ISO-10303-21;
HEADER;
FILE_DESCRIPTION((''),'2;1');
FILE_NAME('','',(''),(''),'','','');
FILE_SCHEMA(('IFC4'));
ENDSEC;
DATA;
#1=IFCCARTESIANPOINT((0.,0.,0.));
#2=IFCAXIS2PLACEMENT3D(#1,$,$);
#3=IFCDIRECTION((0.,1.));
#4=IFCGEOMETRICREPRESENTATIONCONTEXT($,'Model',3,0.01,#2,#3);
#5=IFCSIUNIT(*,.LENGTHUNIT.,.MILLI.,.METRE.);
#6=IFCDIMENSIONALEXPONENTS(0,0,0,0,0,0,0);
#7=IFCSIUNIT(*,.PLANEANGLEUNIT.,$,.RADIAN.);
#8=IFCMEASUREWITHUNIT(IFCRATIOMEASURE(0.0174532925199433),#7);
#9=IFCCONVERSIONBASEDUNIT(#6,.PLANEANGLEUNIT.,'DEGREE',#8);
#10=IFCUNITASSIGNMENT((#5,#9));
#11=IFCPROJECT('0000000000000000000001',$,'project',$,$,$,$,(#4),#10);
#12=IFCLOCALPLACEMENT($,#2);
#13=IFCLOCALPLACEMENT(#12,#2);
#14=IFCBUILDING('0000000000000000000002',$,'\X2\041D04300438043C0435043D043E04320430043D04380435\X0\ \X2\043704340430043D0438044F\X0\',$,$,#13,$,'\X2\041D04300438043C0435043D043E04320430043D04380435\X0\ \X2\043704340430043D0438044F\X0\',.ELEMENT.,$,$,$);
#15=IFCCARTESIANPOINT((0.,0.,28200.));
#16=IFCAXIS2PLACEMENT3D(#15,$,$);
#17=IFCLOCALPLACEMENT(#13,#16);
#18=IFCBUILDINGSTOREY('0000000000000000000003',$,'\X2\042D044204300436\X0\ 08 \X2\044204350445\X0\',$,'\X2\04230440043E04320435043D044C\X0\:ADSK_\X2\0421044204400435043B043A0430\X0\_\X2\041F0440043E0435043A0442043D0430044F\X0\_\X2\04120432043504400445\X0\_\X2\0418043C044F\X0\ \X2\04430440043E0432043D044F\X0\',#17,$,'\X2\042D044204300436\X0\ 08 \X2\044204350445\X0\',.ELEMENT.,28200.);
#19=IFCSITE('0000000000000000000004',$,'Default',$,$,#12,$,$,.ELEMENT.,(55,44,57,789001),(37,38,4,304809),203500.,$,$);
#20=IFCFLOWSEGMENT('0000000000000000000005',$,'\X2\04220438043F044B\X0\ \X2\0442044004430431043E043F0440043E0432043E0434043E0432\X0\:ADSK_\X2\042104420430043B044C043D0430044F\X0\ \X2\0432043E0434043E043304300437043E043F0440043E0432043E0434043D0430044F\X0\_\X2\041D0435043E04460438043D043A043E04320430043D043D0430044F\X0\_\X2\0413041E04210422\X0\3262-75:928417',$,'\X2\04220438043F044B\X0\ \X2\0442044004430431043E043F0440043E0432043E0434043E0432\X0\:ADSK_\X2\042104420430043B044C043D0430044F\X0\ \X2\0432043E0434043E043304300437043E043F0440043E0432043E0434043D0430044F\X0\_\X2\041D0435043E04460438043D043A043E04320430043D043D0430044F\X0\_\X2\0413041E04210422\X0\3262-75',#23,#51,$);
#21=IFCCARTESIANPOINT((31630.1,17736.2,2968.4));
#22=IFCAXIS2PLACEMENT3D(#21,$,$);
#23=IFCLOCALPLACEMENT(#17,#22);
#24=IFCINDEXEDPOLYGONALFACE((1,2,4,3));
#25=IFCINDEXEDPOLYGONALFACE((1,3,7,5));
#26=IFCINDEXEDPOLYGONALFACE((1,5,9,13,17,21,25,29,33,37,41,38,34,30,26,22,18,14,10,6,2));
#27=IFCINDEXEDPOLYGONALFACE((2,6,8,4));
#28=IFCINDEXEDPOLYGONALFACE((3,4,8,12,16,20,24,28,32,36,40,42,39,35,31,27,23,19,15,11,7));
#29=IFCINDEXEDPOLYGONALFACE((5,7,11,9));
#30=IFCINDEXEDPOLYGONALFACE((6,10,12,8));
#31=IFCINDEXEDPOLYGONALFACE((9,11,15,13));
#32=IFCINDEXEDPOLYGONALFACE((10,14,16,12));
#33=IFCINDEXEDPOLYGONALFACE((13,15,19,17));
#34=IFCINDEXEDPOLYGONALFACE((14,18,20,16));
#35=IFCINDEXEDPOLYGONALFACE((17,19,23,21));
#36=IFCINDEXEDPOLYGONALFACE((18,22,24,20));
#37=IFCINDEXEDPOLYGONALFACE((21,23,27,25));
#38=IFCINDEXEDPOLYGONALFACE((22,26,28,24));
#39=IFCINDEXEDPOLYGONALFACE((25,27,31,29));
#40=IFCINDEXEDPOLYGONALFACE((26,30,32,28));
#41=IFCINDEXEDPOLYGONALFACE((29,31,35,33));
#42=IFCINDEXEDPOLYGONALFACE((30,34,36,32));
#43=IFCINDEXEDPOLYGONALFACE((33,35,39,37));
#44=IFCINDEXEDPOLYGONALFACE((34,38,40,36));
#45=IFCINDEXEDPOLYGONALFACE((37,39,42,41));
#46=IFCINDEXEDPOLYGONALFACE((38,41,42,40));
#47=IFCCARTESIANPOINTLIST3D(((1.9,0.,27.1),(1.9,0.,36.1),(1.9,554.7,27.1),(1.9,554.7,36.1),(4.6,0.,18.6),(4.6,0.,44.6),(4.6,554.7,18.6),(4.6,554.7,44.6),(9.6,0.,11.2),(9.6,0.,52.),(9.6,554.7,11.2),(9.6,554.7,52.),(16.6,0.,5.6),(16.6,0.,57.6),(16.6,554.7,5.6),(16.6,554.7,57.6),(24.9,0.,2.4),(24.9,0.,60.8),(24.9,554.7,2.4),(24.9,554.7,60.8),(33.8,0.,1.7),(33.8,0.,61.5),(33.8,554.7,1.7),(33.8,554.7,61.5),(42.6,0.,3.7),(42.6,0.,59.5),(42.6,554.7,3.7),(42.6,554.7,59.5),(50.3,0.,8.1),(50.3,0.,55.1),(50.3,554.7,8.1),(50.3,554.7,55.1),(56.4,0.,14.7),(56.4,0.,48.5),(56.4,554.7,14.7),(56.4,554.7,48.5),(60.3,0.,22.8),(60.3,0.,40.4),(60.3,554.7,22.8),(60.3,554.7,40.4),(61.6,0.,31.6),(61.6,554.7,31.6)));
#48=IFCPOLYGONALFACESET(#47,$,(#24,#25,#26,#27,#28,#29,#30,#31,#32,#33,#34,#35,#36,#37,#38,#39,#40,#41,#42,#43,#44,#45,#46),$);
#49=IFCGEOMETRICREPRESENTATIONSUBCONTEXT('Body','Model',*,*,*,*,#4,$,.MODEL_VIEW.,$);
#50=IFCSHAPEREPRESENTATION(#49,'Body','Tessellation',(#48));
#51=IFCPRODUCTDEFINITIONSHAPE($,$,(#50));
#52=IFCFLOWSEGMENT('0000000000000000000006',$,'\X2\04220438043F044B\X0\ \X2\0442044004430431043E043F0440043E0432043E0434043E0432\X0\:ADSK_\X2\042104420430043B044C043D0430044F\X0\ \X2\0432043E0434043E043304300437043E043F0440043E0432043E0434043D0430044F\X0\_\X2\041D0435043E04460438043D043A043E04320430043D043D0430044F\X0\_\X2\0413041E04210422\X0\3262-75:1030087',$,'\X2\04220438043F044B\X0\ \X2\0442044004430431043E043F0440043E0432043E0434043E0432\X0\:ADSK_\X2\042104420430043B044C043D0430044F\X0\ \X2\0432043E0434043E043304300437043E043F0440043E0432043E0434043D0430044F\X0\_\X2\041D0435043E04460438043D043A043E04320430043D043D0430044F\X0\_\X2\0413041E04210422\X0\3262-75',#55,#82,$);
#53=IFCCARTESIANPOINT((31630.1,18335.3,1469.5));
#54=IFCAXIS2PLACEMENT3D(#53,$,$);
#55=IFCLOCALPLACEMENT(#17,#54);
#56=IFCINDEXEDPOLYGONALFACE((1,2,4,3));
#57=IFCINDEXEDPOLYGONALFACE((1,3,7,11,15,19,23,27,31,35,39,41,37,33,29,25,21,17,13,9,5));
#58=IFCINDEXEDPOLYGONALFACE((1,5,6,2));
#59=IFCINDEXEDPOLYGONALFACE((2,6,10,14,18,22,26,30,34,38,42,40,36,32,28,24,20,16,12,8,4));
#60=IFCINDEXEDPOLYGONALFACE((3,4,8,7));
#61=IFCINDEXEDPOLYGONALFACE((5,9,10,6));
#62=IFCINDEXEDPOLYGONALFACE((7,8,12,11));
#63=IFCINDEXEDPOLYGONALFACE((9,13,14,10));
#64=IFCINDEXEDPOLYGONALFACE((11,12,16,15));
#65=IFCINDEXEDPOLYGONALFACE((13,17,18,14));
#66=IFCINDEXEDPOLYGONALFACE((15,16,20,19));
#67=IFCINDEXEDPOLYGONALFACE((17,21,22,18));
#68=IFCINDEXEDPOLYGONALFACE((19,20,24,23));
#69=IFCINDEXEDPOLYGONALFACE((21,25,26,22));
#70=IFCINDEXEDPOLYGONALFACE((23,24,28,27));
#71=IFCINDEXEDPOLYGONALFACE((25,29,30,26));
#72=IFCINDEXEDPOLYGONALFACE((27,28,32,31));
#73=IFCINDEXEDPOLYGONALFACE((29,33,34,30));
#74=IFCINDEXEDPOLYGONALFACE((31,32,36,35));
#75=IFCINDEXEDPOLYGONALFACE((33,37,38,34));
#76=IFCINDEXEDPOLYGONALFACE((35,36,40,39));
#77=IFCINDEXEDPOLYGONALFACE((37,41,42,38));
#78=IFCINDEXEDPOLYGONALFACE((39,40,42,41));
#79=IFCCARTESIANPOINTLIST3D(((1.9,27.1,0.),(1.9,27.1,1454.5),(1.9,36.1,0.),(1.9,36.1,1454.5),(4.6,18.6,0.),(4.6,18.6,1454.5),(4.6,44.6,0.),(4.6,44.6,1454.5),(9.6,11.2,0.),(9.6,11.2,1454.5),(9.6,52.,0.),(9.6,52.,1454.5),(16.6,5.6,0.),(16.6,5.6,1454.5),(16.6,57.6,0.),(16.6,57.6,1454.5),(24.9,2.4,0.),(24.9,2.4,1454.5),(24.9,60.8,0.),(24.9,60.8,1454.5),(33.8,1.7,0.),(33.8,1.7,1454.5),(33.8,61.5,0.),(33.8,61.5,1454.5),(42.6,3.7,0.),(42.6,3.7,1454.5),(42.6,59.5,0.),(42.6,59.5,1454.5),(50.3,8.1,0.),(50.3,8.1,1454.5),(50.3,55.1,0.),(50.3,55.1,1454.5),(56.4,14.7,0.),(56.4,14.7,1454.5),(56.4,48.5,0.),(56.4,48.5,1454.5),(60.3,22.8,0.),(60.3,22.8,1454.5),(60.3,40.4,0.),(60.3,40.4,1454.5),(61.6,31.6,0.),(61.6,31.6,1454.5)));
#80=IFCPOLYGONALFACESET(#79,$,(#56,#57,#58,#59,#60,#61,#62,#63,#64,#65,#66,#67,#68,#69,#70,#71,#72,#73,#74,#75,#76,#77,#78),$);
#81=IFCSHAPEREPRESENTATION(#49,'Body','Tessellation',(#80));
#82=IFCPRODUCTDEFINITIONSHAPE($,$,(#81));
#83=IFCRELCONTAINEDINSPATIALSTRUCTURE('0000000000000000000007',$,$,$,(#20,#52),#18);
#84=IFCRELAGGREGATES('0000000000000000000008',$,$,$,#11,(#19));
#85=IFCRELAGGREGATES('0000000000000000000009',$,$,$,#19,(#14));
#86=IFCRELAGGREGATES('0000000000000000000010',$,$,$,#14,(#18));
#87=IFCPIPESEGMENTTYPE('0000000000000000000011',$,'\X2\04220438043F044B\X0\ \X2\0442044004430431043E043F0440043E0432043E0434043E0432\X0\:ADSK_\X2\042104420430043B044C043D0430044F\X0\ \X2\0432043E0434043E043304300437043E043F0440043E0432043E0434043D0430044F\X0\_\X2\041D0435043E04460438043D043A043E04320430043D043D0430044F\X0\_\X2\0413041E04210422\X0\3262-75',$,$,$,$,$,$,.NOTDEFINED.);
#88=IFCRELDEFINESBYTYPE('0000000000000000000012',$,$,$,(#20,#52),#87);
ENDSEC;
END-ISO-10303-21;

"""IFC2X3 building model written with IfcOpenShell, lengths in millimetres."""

from ifc_helpers import new_model, entity, si_unit, converted_unit, direction, frame, origin, origin_2d_with_axis, place, context, subcontext, project, spatial, circle, extrude, type_object, element, save


model = new_model("IFC2X3")

# Units and contexts
model_context = context("Model", 3, precision=0.01, world=origin(), true_north=direction((0.0, 1.0)))
body_context = subcontext(model_context, "Body", "Model", "MODEL_VIEW")
ifc_project = project(units=[si_unit("LENGTHUNIT", "METRE", prefix="MILLI"), converted_unit("PLANEANGLEUNIT", "DEGREE", entity("IfcRatioMeasure", 0.0174532925199433), si_unit("PLANEANGLEUNIT", "RADIAN"), dimensions=[0, 0, 0, 0, 0, 0, 0])], contexts=[model_context])

# Site, building, storey
site_placement = place(None, origin())
site = spatial("IfcSite", under=ifc_project, at=site_placement, Name="Default", CompositionType="ELEMENT", RefLatitude=(55, 44, 57, 789001), RefLongitude=(37, 38, 4, 304809), RefElevation=203500.0)
building_placement = place(site_placement, origin())
building = spatial("IfcBuilding", under=site, at=building_placement, Name="Наименование здания", LongName="Наименование здания", CompositionType="ELEMENT")
storey_placement = place(building_placement, frame((0.0, 0.0, 28200.0)))
storey = spatial("IfcBuildingStorey", under=building, at=storey_placement, Name="Этаж 08 тех", ObjectType="Уровень:ADSK_Стрелка_Проектная_Вверх_Имя уровня", LongName="Этаж 08 тех", CompositionType="ELEMENT", Elevation=28200.0)

# Flow segments
pipe_segment_type_1 = type_object("IfcPipeSegmentType", Name="Типы трубопроводов:ADSK_Стальная водогазопроводная_Неоцинкованная_ГОСТ3262-75", PredefinedType="NOTDEFINED")
flow_segment_1_placement = place(storey_placement, frame((31630.1, 17736.2, 2968.4)))
element("IfcFlowSegment", 1, at=flow_segment_1_placement, inside=storey, type_object=pipe_segment_type_1, Name="Типы трубопроводов:ADSK_Стальная водогазопроводная_Неоцинкованная_ГОСТ3262-75:928417", ObjectType="Типы трубопроводов:ADSK_Стальная водогазопроводная_Неоцинкованная_ГОСТ3262-75", context=body_context, shape_type="SweptSolid", body=[
    extrude(circle(Radius=30.0, at=origin_2d_with_axis()), frame((31.6, 0.0, 31.6), z_axis=(0.0, 1.0, 0.0), x_axis=(1.0, 0.0, 0.0)), (0.0, 0.0, 1.0), 554.7),
])
flow_segment_2_placement = place(storey_placement, frame((31630.1, 18335.3, 1469.5)))
element("IfcFlowSegment", 2, at=flow_segment_2_placement, inside=storey, type_object=pipe_segment_type_1, Name="Типы трубопроводов:ADSK_Стальная водогазопроводная_Неоцинкованная_ГОСТ3262-75:1030087", ObjectType="Типы трубопроводов:ADSK_Стальная водогазопроводная_Неоцинкованная_ГОСТ3262-75", context=body_context, shape_type="SweptSolid", body=[
    extrude(circle(Radius=30.0, at=origin_2d_with_axis()), frame((31.6, 31.6, 0.0)), (0.0, 0.0, 1.0), 1454.5),
])

save(model, "model.ifc")
